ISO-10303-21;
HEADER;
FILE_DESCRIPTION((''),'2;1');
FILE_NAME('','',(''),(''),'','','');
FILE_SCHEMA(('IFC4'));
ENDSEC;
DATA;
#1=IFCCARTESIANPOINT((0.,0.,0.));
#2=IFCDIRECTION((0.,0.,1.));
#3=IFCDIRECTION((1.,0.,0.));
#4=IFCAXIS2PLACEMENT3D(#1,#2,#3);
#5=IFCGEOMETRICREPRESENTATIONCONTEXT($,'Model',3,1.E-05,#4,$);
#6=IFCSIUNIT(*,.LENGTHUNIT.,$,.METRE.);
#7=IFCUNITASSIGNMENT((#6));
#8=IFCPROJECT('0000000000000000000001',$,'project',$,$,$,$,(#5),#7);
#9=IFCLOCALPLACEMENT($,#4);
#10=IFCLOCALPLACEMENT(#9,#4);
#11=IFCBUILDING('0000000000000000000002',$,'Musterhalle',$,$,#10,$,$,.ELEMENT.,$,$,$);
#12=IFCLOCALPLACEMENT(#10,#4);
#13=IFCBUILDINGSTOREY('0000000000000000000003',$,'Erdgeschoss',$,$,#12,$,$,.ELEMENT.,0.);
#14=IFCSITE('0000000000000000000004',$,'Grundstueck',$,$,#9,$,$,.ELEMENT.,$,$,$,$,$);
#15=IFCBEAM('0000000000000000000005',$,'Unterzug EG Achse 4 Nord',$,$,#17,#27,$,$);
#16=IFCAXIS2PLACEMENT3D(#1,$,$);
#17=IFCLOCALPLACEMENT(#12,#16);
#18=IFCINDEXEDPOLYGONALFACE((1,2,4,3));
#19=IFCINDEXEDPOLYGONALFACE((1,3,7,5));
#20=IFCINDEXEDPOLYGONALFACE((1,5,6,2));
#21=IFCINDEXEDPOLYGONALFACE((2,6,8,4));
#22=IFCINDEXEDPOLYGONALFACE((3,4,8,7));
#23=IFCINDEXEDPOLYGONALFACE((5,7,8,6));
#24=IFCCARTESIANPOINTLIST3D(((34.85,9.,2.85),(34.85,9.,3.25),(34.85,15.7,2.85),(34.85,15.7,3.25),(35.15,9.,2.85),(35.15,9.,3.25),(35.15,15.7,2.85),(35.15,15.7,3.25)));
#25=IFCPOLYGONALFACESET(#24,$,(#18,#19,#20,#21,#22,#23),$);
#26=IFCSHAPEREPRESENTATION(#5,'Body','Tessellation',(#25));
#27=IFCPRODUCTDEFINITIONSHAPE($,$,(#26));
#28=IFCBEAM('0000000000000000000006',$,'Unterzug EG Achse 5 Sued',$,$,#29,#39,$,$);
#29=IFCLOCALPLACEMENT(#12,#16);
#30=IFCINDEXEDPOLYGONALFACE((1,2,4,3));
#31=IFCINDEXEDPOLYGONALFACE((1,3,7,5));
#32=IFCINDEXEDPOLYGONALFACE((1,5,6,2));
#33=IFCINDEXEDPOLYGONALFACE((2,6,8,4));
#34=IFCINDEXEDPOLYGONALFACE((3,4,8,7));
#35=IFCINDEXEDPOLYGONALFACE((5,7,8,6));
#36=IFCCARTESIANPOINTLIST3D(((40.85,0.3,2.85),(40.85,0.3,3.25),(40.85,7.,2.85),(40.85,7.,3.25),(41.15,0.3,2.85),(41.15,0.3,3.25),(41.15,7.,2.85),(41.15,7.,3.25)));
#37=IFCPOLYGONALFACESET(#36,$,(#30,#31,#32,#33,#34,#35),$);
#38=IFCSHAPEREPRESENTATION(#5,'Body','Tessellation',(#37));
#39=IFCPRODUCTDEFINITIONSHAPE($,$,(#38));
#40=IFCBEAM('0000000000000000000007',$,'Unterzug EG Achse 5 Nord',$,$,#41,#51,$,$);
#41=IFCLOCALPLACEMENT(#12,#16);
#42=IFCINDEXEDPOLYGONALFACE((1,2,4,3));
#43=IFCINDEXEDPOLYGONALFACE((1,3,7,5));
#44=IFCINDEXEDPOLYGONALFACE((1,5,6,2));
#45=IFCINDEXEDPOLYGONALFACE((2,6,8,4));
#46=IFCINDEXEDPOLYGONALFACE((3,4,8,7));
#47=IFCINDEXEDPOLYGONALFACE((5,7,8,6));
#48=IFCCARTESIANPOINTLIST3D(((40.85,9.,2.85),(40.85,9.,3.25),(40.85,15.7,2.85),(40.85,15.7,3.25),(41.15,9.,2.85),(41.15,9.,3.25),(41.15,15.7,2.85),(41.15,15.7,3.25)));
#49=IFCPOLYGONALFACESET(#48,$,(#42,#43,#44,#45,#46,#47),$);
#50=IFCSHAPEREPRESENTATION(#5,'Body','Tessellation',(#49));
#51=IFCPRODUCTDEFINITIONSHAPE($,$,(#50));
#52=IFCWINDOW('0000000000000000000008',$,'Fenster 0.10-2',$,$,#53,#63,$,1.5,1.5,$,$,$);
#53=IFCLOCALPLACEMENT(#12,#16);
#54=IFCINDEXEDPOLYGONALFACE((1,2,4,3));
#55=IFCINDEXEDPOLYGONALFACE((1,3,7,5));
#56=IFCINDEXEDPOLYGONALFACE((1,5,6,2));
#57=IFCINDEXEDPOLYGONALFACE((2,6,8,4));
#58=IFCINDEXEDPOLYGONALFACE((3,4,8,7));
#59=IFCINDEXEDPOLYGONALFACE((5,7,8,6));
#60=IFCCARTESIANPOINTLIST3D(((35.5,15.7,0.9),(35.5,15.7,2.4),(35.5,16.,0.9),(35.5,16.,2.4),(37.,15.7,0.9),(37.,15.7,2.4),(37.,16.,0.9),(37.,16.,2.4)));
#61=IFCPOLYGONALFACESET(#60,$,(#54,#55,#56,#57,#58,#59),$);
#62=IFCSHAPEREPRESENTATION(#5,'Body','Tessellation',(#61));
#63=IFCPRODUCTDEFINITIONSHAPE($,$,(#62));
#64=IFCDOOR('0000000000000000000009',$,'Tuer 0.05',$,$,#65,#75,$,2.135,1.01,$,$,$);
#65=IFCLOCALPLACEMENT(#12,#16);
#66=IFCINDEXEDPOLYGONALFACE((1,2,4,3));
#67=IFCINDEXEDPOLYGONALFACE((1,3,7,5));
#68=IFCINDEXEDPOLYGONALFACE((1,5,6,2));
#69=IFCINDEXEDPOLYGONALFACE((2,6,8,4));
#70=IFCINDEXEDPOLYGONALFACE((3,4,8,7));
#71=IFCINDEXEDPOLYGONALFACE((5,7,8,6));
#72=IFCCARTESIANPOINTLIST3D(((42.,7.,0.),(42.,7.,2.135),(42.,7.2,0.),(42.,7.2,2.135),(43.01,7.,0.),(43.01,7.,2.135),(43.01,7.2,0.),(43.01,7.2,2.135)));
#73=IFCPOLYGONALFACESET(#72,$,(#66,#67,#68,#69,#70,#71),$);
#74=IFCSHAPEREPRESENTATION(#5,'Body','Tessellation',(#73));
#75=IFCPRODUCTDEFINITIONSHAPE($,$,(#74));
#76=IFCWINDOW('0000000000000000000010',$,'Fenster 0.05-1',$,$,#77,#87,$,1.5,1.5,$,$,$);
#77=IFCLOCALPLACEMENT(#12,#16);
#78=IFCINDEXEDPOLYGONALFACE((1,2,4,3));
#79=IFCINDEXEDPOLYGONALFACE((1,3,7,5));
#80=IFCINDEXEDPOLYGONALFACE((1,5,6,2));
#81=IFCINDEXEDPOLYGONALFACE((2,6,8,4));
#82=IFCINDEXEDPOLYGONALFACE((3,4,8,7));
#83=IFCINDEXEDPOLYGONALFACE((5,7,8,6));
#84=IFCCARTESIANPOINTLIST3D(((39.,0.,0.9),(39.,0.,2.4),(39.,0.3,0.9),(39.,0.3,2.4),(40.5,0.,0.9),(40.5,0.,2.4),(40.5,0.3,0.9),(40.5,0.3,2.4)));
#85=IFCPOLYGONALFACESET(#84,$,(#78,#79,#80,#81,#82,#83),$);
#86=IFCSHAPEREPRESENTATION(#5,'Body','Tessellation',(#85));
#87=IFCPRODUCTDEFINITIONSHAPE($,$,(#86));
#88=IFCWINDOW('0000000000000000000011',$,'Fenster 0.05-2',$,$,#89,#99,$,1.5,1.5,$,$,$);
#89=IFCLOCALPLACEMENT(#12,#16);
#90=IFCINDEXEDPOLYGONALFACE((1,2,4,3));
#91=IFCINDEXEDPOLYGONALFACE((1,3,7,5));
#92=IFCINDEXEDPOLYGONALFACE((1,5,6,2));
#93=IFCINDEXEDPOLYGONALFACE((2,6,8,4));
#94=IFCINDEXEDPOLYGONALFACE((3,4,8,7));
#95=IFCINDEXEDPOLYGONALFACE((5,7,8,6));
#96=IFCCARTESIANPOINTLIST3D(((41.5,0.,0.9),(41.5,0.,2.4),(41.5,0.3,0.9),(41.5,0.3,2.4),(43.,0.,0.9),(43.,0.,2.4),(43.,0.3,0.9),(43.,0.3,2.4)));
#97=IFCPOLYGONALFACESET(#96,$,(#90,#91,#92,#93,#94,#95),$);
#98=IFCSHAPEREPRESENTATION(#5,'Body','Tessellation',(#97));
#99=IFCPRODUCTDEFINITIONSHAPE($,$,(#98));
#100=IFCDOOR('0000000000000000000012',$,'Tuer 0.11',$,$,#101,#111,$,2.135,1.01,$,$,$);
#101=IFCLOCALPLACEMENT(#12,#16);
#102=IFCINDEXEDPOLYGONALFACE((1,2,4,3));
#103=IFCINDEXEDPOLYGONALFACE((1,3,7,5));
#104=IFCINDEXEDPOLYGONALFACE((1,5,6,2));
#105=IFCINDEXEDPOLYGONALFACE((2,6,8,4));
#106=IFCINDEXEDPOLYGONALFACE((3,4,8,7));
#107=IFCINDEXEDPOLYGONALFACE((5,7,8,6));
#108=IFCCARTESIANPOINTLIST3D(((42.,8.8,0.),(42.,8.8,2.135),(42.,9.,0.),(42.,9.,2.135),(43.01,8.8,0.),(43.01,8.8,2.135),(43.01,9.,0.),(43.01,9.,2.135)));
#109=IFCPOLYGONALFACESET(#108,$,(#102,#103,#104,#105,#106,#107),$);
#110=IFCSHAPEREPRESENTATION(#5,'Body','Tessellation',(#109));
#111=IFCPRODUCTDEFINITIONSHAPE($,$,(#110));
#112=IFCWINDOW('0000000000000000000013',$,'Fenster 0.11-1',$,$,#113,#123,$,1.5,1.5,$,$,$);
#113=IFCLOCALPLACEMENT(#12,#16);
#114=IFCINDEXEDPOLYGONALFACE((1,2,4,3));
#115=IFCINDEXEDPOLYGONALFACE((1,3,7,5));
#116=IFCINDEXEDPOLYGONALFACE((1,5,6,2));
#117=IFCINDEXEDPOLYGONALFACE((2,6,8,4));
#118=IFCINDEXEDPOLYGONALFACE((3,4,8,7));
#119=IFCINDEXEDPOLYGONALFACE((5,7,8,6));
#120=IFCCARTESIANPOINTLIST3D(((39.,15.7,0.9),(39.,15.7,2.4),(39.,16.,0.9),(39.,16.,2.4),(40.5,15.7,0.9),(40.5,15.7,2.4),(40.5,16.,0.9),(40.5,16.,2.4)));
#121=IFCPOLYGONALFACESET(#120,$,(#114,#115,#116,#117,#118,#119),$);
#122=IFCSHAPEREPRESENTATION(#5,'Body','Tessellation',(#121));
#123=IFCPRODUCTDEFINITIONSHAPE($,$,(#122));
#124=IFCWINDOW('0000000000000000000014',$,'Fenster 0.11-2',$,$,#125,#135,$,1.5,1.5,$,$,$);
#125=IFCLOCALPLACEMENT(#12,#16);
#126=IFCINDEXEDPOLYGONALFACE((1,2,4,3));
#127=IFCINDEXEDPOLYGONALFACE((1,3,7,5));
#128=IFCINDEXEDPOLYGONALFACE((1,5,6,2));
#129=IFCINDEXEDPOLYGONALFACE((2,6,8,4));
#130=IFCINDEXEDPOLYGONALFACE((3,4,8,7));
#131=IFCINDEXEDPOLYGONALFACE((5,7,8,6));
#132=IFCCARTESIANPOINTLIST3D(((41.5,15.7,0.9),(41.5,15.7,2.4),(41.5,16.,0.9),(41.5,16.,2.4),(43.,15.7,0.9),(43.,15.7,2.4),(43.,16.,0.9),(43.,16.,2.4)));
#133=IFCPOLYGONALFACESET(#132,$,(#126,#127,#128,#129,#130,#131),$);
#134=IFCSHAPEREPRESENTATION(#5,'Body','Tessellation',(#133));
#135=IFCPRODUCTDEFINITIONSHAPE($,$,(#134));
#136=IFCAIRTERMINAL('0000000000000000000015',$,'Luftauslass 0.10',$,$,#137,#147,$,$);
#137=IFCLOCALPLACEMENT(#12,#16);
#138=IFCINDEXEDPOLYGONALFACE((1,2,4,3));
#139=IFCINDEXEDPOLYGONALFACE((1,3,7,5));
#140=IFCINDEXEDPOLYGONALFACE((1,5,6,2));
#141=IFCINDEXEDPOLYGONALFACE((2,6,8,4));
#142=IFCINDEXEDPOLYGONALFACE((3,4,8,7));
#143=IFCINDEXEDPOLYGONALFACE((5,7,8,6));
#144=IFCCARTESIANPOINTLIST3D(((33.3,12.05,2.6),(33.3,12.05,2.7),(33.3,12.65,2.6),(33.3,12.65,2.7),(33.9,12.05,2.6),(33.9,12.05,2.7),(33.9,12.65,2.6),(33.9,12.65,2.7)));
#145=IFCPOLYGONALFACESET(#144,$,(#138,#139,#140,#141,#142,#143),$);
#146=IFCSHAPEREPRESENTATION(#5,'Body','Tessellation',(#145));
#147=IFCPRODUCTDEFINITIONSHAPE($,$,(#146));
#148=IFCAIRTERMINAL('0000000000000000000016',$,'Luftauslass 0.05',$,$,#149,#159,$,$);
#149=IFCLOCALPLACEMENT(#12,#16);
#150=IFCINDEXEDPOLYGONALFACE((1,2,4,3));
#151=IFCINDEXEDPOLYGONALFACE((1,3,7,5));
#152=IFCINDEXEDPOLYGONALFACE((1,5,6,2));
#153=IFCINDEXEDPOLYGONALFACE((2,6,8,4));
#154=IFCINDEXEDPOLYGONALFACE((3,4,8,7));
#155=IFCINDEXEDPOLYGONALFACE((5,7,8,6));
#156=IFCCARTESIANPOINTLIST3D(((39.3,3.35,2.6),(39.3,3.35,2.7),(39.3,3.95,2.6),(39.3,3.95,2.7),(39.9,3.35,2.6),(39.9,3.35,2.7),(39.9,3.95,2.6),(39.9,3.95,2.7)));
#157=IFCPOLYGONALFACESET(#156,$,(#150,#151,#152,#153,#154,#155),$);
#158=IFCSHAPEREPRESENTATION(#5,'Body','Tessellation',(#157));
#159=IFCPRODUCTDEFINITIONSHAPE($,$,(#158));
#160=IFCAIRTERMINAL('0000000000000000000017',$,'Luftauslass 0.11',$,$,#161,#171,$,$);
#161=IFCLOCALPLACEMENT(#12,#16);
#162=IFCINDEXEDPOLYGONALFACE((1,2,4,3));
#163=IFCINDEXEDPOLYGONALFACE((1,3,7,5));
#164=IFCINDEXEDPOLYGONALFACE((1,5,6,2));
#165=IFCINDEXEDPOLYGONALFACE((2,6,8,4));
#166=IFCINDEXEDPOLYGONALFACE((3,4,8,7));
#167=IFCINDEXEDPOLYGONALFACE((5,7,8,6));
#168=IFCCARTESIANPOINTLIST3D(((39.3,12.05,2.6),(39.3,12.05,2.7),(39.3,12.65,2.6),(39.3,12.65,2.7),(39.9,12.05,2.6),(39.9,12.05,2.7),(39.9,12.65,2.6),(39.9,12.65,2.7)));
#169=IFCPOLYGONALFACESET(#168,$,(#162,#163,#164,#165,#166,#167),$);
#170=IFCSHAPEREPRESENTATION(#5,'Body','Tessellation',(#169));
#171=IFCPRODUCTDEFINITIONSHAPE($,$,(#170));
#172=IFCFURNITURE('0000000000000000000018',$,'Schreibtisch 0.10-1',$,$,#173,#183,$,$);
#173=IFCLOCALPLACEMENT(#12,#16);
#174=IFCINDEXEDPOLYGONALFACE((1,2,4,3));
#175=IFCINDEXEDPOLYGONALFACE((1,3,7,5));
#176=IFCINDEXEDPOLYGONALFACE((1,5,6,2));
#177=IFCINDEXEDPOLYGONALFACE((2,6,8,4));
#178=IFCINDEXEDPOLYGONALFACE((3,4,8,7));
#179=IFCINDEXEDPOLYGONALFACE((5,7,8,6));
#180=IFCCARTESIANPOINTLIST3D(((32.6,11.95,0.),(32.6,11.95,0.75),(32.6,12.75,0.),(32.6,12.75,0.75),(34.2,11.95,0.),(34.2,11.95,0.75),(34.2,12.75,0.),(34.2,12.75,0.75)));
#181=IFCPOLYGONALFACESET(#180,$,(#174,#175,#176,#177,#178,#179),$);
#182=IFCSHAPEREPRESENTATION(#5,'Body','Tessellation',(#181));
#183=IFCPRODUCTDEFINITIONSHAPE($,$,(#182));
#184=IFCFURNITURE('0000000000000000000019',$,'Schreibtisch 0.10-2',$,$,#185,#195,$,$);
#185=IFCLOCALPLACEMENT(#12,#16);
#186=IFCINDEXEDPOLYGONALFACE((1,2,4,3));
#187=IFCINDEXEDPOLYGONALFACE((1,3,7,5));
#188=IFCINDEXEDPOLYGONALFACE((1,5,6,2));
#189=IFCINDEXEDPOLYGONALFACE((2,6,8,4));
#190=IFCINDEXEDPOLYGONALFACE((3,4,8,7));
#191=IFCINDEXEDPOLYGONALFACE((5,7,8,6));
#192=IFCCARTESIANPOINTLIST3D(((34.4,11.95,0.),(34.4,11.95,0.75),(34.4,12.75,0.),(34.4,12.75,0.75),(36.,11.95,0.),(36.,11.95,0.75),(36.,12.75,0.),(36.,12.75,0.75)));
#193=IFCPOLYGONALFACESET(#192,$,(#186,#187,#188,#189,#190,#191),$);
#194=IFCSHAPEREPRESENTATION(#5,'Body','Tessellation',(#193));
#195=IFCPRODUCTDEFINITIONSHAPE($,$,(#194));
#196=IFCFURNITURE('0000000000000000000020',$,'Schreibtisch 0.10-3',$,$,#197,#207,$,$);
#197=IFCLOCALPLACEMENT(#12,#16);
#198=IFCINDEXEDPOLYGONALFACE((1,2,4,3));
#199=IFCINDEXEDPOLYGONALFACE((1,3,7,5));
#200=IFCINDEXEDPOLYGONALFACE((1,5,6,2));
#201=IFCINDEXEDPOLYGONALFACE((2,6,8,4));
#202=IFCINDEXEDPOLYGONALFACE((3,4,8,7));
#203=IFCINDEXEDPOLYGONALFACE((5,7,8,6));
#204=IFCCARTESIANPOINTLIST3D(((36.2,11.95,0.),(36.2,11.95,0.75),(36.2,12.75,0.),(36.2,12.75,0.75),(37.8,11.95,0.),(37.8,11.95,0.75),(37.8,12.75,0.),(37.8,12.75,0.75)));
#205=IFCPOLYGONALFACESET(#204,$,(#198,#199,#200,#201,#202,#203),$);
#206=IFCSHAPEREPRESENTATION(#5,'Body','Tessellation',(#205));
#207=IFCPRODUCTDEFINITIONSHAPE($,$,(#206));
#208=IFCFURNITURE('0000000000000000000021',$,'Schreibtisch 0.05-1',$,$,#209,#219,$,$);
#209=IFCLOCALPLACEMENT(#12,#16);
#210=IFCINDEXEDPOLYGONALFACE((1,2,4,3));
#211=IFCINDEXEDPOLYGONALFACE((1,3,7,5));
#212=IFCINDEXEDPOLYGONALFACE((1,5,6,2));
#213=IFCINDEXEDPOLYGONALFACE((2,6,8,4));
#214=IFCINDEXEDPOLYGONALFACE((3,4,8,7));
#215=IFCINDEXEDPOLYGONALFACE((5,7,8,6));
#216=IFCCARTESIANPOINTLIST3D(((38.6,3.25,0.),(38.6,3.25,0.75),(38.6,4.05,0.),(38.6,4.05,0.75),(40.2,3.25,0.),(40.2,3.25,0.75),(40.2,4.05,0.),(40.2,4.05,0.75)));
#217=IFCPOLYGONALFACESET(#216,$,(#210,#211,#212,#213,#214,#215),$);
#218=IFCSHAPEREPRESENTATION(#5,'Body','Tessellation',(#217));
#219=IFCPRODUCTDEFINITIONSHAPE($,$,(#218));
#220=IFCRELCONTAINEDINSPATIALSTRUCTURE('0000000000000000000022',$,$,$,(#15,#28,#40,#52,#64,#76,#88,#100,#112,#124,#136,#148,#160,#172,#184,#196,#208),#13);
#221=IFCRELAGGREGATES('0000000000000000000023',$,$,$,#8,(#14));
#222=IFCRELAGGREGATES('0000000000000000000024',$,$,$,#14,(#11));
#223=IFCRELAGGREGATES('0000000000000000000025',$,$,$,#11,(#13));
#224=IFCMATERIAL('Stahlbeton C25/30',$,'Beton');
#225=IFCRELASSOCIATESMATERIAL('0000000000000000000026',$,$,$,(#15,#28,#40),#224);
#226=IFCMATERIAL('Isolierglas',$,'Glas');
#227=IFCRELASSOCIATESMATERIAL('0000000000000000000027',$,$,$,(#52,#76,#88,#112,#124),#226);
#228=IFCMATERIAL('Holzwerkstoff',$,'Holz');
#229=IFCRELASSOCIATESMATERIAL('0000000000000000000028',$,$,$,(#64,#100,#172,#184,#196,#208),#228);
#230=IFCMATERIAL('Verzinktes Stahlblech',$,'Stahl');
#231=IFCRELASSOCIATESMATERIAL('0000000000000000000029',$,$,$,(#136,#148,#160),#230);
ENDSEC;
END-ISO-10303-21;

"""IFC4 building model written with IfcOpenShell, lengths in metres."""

from ifc_helpers import new_model, si_unit, frame, origin_with_axes, origin_2d, place, context, project, spatial, rectangle, extrude, material, element, save


model = new_model("IFC4")

# Units and contexts
model_context = context("Model", 3, precision=1e-05, world=origin_with_axes())
ifc_project = project(units=[si_unit("LENGTHUNIT", "METRE")], contexts=[model_context])

# Site, building, storey
site_placement = place(None, origin_with_axes())
site = spatial("IfcSite", under=ifc_project, at=site_placement, Name="Grundstueck", CompositionType="ELEMENT")
building_placement = place(site_placement, origin_with_axes())
building = spatial("IfcBuilding", under=site, at=building_placement, Name="Musterhalle", CompositionType="ELEMENT")
storey_placement = place(building_placement, origin_with_axes())
storey = spatial("IfcBuildingStorey", under=building, at=storey_placement, Name="Erdgeschoss", CompositionType="ELEMENT", Elevation=0.0)

# Beams
ifc_material_1 = material(Name="Stahlbeton C25/30", Category="Beton")
placement = place(storey_placement, origin_with_axes())
element("IfcBeam", 1, at=placement, inside=storey, material=ifc_material_1, Name="Unterzug EG Achse 4 Nord", context=model_context, shape_type="SweptSolid", body=[
    extrude(rectangle(XDim=0.3, YDim=6.7, at=origin_2d()), frame((35.0, 12.35, 2.85), z_axis=(0.0, 0.0, 1.0), x_axis=(1.0, 0.0, 0.0)), (0.0, 0.0, 1.0), 0.4),
])
element("IfcBeam", 2, at=placement, inside=storey, material=ifc_material_1, Name="Unterzug EG Achse 5 Sued", context=model_context, shape_type="SweptSolid", body=[
    extrude(rectangle(XDim=0.3, YDim=6.7, at=origin_2d()), frame((41.0, 3.65, 2.85), z_axis=(0.0, 0.0, 1.0), x_axis=(1.0, 0.0, 0.0)), (0.0, 0.0, 1.0), 0.4),
])
element("IfcBeam", 3, at=placement, inside=storey, material=ifc_material_1, Name="Unterzug EG Achse 5 Nord", context=model_context, shape_type="SweptSolid", body=[
    extrude(rectangle(XDim=0.3, YDim=6.7, at=origin_2d()), frame((41.0, 12.35, 2.85), z_axis=(0.0, 0.0, 1.0), x_axis=(1.0, 0.0, 0.0)), (0.0, 0.0, 1.0), 0.4),
])

# Window
ifc_material_2 = material(Name="Isolierglas", Category="Glas")
element("IfcWindow", 4, at=placement, inside=storey, material=ifc_material_2, Name="Fenster 0.10-2", OverallHeight=1.5, OverallWidth=1.5, context=model_context, shape_type="SweptSolid", body=[
    extrude(rectangle(XDim=1.5, YDim=0.3, at=origin_2d()), frame((36.25, 15.85, 0.9), z_axis=(0.0, 0.0, 1.0), x_axis=(1.0, 0.0, 0.0)), (0.0, 0.0, 1.0), 1.5),
])

# Door
ifc_material_3 = material(Name="Holzwerkstoff", Category="Holz")
element("IfcDoor", 5, at=placement, inside=storey, material=ifc_material_3, Name="Tuer 0.05", OverallHeight=2.135, OverallWidth=1.01, context=model_context, shape_type="SweptSolid", body=[
    extrude(rectangle(XDim=1.01, YDim=0.2, at=origin_2d()), frame((42.505, 7.1, 0.0), z_axis=(0.0, 0.0, 1.0), x_axis=(1.0, 0.0, 0.0)), (0.0, 0.0, 1.0), 2.135),
])

# Windows
element("IfcWindow", 6, at=placement, inside=storey, material=ifc_material_2, Name="Fenster 0.05-1", OverallHeight=1.5, OverallWidth=1.5, context=model_context, shape_type="SweptSolid", body=[
    extrude(rectangle(XDim=1.5, YDim=0.3, at=origin_2d()), frame((39.75, 0.15, 0.9), z_axis=(0.0, 0.0, 1.0), x_axis=(1.0, 0.0, 0.0)), (0.0, 0.0, 1.0), 1.5),
])
element("IfcWindow", 7, at=placement, inside=storey, material=ifc_material_2, Name="Fenster 0.05-2", OverallHeight=1.5, OverallWidth=1.5, context=model_context, shape_type="SweptSolid", body=[
    extrude(rectangle(XDim=1.5, YDim=0.3, at=origin_2d()), frame((42.25, 0.15, 0.9), z_axis=(0.0, 0.0, 1.0), x_axis=(1.0, 0.0, 0.0)), (0.0, 0.0, 1.0), 1.5),
])

# Door
element("IfcDoor", 8, at=placement, inside=storey, material=ifc_material_3, Name="Tuer 0.11", OverallHeight=2.135, OverallWidth=1.01, context=model_context, shape_type="SweptSolid", body=[
    extrude(rectangle(XDim=1.01, YDim=0.2, at=origin_2d()), frame((42.505, 8.9, 0.0), z_axis=(0.0, 0.0, 1.0), x_axis=(1.0, 0.0, 0.0)), (0.0, 0.0, 1.0), 2.135),
])

# Windows
element("IfcWindow", 9, at=placement, inside=storey, material=ifc_material_2, Name="Fenster 0.11-1", OverallHeight=1.5, OverallWidth=1.5, context=model_context, shape_type="SweptSolid", body=[
    extrude(rectangle(XDim=1.5, YDim=0.3, at=origin_2d()), frame((39.75, 15.85, 0.9), z_axis=(0.0, 0.0, 1.0), x_axis=(1.0, 0.0, 0.0)), (0.0, 0.0, 1.0), 1.5),
])
element("IfcWindow", 10, at=placement, inside=storey, material=ifc_material_2, Name="Fenster 0.11-2", OverallHeight=1.5, OverallWidth=1.5, context=model_context, shape_type="SweptSolid", body=[
    extrude(rectangle(XDim=1.5, YDim=0.3, at=origin_2d()), frame((42.25, 15.85, 0.9), z_axis=(0.0, 0.0, 1.0), x_axis=(1.0, 0.0, 0.0)), (0.0, 0.0, 1.0), 1.5),
])

# Air terminals
ifc_material_4 = material(Name="Verzinktes Stahlblech", Category="Stahl")
element("IfcAirTerminal", 11, at=placement, inside=storey, material=ifc_material_4, Name="Luftauslass 0.10", context=model_context, shape_type="SweptSolid", body=[
    extrude(rectangle(XDim=0.6, YDim=0.6, at=origin_2d()), frame((33.6, 12.35, 2.6), z_axis=(0.0, 0.0, 1.0), x_axis=(1.0, 0.0, 0.0)), (0.0, 0.0, 1.0), 0.1),
])
element("IfcAirTerminal", 12, at=placement, inside=storey, material=ifc_material_4, Name="Luftauslass 0.05", context=model_context, shape_type="SweptSolid", body=[
    extrude(rectangle(XDim=0.6, YDim=0.6, at=origin_2d()), frame((39.6, 3.65, 2.6), z_axis=(0.0, 0.0, 1.0), x_axis=(1.0, 0.0, 0.0)), (0.0, 0.0, 1.0), 0.1),
])
element("IfcAirTerminal", 13, at=placement, inside=storey, material=ifc_material_4, Name="Luftauslass 0.11", context=model_context, shape_type="SweptSolid", body=[
    extrude(rectangle(XDim=0.6, YDim=0.6, at=origin_2d()), frame((39.6, 12.35, 2.6), z_axis=(0.0, 0.0, 1.0), x_axis=(1.0, 0.0, 0.0)), (0.0, 0.0, 1.0), 0.1),
])

# Furniture
element("IfcFurniture", 14, at=placement, inside=storey, material=ifc_material_3, Name="Schreibtisch 0.10-1", context=model_context, shape_type="SweptSolid", body=[
    extrude(rectangle(XDim=1.6, YDim=0.8, at=origin_2d()), frame((33.4, 12.35, 0.0), z_axis=(0.0, 0.0, 1.0), x_axis=(1.0, 0.0, 0.0)), (0.0, 0.0, 1.0), 0.75),
])
element("IfcFurniture", 15, at=placement, inside=storey, material=ifc_material_3, Name="Schreibtisch 0.10-2", context=model_context, shape_type="SweptSolid", body=[
    extrude(rectangle(XDim=1.6, YDim=0.8, at=origin_2d()), frame((35.2, 12.35, 0.0), z_axis=(0.0, 0.0, 1.0), x_axis=(1.0, 0.0, 0.0)), (0.0, 0.0, 1.0), 0.75),
])
element("IfcFurniture", 16, at=placement, inside=storey, material=ifc_material_3, Name="Schreibtisch 0.10-3", context=model_context, shape_type="SweptSolid", body=[
    extrude(rectangle(XDim=1.6, YDim=0.8, at=origin_2d()), frame((37.0, 12.35, 0.0), z_axis=(0.0, 0.0, 1.0), x_axis=(1.0, 0.0, 0.0)), (0.0, 0.0, 1.0), 0.75),
])
element("IfcFurniture", 17, at=placement, inside=storey, material=ifc_material_3, Name="Schreibtisch 0.05-1", context=model_context, shape_type="SweptSolid", body=[
    extrude(rectangle(XDim=1.6, YDim=0.8, at=origin_2d()), frame((39.4, 3.65, 0.0), z_axis=(0.0, 0.0, 1.0), x_axis=(1.0, 0.0, 0.0)), (0.0, 0.0, 1.0), 0.75),
])

save(model, "model.ifc")
